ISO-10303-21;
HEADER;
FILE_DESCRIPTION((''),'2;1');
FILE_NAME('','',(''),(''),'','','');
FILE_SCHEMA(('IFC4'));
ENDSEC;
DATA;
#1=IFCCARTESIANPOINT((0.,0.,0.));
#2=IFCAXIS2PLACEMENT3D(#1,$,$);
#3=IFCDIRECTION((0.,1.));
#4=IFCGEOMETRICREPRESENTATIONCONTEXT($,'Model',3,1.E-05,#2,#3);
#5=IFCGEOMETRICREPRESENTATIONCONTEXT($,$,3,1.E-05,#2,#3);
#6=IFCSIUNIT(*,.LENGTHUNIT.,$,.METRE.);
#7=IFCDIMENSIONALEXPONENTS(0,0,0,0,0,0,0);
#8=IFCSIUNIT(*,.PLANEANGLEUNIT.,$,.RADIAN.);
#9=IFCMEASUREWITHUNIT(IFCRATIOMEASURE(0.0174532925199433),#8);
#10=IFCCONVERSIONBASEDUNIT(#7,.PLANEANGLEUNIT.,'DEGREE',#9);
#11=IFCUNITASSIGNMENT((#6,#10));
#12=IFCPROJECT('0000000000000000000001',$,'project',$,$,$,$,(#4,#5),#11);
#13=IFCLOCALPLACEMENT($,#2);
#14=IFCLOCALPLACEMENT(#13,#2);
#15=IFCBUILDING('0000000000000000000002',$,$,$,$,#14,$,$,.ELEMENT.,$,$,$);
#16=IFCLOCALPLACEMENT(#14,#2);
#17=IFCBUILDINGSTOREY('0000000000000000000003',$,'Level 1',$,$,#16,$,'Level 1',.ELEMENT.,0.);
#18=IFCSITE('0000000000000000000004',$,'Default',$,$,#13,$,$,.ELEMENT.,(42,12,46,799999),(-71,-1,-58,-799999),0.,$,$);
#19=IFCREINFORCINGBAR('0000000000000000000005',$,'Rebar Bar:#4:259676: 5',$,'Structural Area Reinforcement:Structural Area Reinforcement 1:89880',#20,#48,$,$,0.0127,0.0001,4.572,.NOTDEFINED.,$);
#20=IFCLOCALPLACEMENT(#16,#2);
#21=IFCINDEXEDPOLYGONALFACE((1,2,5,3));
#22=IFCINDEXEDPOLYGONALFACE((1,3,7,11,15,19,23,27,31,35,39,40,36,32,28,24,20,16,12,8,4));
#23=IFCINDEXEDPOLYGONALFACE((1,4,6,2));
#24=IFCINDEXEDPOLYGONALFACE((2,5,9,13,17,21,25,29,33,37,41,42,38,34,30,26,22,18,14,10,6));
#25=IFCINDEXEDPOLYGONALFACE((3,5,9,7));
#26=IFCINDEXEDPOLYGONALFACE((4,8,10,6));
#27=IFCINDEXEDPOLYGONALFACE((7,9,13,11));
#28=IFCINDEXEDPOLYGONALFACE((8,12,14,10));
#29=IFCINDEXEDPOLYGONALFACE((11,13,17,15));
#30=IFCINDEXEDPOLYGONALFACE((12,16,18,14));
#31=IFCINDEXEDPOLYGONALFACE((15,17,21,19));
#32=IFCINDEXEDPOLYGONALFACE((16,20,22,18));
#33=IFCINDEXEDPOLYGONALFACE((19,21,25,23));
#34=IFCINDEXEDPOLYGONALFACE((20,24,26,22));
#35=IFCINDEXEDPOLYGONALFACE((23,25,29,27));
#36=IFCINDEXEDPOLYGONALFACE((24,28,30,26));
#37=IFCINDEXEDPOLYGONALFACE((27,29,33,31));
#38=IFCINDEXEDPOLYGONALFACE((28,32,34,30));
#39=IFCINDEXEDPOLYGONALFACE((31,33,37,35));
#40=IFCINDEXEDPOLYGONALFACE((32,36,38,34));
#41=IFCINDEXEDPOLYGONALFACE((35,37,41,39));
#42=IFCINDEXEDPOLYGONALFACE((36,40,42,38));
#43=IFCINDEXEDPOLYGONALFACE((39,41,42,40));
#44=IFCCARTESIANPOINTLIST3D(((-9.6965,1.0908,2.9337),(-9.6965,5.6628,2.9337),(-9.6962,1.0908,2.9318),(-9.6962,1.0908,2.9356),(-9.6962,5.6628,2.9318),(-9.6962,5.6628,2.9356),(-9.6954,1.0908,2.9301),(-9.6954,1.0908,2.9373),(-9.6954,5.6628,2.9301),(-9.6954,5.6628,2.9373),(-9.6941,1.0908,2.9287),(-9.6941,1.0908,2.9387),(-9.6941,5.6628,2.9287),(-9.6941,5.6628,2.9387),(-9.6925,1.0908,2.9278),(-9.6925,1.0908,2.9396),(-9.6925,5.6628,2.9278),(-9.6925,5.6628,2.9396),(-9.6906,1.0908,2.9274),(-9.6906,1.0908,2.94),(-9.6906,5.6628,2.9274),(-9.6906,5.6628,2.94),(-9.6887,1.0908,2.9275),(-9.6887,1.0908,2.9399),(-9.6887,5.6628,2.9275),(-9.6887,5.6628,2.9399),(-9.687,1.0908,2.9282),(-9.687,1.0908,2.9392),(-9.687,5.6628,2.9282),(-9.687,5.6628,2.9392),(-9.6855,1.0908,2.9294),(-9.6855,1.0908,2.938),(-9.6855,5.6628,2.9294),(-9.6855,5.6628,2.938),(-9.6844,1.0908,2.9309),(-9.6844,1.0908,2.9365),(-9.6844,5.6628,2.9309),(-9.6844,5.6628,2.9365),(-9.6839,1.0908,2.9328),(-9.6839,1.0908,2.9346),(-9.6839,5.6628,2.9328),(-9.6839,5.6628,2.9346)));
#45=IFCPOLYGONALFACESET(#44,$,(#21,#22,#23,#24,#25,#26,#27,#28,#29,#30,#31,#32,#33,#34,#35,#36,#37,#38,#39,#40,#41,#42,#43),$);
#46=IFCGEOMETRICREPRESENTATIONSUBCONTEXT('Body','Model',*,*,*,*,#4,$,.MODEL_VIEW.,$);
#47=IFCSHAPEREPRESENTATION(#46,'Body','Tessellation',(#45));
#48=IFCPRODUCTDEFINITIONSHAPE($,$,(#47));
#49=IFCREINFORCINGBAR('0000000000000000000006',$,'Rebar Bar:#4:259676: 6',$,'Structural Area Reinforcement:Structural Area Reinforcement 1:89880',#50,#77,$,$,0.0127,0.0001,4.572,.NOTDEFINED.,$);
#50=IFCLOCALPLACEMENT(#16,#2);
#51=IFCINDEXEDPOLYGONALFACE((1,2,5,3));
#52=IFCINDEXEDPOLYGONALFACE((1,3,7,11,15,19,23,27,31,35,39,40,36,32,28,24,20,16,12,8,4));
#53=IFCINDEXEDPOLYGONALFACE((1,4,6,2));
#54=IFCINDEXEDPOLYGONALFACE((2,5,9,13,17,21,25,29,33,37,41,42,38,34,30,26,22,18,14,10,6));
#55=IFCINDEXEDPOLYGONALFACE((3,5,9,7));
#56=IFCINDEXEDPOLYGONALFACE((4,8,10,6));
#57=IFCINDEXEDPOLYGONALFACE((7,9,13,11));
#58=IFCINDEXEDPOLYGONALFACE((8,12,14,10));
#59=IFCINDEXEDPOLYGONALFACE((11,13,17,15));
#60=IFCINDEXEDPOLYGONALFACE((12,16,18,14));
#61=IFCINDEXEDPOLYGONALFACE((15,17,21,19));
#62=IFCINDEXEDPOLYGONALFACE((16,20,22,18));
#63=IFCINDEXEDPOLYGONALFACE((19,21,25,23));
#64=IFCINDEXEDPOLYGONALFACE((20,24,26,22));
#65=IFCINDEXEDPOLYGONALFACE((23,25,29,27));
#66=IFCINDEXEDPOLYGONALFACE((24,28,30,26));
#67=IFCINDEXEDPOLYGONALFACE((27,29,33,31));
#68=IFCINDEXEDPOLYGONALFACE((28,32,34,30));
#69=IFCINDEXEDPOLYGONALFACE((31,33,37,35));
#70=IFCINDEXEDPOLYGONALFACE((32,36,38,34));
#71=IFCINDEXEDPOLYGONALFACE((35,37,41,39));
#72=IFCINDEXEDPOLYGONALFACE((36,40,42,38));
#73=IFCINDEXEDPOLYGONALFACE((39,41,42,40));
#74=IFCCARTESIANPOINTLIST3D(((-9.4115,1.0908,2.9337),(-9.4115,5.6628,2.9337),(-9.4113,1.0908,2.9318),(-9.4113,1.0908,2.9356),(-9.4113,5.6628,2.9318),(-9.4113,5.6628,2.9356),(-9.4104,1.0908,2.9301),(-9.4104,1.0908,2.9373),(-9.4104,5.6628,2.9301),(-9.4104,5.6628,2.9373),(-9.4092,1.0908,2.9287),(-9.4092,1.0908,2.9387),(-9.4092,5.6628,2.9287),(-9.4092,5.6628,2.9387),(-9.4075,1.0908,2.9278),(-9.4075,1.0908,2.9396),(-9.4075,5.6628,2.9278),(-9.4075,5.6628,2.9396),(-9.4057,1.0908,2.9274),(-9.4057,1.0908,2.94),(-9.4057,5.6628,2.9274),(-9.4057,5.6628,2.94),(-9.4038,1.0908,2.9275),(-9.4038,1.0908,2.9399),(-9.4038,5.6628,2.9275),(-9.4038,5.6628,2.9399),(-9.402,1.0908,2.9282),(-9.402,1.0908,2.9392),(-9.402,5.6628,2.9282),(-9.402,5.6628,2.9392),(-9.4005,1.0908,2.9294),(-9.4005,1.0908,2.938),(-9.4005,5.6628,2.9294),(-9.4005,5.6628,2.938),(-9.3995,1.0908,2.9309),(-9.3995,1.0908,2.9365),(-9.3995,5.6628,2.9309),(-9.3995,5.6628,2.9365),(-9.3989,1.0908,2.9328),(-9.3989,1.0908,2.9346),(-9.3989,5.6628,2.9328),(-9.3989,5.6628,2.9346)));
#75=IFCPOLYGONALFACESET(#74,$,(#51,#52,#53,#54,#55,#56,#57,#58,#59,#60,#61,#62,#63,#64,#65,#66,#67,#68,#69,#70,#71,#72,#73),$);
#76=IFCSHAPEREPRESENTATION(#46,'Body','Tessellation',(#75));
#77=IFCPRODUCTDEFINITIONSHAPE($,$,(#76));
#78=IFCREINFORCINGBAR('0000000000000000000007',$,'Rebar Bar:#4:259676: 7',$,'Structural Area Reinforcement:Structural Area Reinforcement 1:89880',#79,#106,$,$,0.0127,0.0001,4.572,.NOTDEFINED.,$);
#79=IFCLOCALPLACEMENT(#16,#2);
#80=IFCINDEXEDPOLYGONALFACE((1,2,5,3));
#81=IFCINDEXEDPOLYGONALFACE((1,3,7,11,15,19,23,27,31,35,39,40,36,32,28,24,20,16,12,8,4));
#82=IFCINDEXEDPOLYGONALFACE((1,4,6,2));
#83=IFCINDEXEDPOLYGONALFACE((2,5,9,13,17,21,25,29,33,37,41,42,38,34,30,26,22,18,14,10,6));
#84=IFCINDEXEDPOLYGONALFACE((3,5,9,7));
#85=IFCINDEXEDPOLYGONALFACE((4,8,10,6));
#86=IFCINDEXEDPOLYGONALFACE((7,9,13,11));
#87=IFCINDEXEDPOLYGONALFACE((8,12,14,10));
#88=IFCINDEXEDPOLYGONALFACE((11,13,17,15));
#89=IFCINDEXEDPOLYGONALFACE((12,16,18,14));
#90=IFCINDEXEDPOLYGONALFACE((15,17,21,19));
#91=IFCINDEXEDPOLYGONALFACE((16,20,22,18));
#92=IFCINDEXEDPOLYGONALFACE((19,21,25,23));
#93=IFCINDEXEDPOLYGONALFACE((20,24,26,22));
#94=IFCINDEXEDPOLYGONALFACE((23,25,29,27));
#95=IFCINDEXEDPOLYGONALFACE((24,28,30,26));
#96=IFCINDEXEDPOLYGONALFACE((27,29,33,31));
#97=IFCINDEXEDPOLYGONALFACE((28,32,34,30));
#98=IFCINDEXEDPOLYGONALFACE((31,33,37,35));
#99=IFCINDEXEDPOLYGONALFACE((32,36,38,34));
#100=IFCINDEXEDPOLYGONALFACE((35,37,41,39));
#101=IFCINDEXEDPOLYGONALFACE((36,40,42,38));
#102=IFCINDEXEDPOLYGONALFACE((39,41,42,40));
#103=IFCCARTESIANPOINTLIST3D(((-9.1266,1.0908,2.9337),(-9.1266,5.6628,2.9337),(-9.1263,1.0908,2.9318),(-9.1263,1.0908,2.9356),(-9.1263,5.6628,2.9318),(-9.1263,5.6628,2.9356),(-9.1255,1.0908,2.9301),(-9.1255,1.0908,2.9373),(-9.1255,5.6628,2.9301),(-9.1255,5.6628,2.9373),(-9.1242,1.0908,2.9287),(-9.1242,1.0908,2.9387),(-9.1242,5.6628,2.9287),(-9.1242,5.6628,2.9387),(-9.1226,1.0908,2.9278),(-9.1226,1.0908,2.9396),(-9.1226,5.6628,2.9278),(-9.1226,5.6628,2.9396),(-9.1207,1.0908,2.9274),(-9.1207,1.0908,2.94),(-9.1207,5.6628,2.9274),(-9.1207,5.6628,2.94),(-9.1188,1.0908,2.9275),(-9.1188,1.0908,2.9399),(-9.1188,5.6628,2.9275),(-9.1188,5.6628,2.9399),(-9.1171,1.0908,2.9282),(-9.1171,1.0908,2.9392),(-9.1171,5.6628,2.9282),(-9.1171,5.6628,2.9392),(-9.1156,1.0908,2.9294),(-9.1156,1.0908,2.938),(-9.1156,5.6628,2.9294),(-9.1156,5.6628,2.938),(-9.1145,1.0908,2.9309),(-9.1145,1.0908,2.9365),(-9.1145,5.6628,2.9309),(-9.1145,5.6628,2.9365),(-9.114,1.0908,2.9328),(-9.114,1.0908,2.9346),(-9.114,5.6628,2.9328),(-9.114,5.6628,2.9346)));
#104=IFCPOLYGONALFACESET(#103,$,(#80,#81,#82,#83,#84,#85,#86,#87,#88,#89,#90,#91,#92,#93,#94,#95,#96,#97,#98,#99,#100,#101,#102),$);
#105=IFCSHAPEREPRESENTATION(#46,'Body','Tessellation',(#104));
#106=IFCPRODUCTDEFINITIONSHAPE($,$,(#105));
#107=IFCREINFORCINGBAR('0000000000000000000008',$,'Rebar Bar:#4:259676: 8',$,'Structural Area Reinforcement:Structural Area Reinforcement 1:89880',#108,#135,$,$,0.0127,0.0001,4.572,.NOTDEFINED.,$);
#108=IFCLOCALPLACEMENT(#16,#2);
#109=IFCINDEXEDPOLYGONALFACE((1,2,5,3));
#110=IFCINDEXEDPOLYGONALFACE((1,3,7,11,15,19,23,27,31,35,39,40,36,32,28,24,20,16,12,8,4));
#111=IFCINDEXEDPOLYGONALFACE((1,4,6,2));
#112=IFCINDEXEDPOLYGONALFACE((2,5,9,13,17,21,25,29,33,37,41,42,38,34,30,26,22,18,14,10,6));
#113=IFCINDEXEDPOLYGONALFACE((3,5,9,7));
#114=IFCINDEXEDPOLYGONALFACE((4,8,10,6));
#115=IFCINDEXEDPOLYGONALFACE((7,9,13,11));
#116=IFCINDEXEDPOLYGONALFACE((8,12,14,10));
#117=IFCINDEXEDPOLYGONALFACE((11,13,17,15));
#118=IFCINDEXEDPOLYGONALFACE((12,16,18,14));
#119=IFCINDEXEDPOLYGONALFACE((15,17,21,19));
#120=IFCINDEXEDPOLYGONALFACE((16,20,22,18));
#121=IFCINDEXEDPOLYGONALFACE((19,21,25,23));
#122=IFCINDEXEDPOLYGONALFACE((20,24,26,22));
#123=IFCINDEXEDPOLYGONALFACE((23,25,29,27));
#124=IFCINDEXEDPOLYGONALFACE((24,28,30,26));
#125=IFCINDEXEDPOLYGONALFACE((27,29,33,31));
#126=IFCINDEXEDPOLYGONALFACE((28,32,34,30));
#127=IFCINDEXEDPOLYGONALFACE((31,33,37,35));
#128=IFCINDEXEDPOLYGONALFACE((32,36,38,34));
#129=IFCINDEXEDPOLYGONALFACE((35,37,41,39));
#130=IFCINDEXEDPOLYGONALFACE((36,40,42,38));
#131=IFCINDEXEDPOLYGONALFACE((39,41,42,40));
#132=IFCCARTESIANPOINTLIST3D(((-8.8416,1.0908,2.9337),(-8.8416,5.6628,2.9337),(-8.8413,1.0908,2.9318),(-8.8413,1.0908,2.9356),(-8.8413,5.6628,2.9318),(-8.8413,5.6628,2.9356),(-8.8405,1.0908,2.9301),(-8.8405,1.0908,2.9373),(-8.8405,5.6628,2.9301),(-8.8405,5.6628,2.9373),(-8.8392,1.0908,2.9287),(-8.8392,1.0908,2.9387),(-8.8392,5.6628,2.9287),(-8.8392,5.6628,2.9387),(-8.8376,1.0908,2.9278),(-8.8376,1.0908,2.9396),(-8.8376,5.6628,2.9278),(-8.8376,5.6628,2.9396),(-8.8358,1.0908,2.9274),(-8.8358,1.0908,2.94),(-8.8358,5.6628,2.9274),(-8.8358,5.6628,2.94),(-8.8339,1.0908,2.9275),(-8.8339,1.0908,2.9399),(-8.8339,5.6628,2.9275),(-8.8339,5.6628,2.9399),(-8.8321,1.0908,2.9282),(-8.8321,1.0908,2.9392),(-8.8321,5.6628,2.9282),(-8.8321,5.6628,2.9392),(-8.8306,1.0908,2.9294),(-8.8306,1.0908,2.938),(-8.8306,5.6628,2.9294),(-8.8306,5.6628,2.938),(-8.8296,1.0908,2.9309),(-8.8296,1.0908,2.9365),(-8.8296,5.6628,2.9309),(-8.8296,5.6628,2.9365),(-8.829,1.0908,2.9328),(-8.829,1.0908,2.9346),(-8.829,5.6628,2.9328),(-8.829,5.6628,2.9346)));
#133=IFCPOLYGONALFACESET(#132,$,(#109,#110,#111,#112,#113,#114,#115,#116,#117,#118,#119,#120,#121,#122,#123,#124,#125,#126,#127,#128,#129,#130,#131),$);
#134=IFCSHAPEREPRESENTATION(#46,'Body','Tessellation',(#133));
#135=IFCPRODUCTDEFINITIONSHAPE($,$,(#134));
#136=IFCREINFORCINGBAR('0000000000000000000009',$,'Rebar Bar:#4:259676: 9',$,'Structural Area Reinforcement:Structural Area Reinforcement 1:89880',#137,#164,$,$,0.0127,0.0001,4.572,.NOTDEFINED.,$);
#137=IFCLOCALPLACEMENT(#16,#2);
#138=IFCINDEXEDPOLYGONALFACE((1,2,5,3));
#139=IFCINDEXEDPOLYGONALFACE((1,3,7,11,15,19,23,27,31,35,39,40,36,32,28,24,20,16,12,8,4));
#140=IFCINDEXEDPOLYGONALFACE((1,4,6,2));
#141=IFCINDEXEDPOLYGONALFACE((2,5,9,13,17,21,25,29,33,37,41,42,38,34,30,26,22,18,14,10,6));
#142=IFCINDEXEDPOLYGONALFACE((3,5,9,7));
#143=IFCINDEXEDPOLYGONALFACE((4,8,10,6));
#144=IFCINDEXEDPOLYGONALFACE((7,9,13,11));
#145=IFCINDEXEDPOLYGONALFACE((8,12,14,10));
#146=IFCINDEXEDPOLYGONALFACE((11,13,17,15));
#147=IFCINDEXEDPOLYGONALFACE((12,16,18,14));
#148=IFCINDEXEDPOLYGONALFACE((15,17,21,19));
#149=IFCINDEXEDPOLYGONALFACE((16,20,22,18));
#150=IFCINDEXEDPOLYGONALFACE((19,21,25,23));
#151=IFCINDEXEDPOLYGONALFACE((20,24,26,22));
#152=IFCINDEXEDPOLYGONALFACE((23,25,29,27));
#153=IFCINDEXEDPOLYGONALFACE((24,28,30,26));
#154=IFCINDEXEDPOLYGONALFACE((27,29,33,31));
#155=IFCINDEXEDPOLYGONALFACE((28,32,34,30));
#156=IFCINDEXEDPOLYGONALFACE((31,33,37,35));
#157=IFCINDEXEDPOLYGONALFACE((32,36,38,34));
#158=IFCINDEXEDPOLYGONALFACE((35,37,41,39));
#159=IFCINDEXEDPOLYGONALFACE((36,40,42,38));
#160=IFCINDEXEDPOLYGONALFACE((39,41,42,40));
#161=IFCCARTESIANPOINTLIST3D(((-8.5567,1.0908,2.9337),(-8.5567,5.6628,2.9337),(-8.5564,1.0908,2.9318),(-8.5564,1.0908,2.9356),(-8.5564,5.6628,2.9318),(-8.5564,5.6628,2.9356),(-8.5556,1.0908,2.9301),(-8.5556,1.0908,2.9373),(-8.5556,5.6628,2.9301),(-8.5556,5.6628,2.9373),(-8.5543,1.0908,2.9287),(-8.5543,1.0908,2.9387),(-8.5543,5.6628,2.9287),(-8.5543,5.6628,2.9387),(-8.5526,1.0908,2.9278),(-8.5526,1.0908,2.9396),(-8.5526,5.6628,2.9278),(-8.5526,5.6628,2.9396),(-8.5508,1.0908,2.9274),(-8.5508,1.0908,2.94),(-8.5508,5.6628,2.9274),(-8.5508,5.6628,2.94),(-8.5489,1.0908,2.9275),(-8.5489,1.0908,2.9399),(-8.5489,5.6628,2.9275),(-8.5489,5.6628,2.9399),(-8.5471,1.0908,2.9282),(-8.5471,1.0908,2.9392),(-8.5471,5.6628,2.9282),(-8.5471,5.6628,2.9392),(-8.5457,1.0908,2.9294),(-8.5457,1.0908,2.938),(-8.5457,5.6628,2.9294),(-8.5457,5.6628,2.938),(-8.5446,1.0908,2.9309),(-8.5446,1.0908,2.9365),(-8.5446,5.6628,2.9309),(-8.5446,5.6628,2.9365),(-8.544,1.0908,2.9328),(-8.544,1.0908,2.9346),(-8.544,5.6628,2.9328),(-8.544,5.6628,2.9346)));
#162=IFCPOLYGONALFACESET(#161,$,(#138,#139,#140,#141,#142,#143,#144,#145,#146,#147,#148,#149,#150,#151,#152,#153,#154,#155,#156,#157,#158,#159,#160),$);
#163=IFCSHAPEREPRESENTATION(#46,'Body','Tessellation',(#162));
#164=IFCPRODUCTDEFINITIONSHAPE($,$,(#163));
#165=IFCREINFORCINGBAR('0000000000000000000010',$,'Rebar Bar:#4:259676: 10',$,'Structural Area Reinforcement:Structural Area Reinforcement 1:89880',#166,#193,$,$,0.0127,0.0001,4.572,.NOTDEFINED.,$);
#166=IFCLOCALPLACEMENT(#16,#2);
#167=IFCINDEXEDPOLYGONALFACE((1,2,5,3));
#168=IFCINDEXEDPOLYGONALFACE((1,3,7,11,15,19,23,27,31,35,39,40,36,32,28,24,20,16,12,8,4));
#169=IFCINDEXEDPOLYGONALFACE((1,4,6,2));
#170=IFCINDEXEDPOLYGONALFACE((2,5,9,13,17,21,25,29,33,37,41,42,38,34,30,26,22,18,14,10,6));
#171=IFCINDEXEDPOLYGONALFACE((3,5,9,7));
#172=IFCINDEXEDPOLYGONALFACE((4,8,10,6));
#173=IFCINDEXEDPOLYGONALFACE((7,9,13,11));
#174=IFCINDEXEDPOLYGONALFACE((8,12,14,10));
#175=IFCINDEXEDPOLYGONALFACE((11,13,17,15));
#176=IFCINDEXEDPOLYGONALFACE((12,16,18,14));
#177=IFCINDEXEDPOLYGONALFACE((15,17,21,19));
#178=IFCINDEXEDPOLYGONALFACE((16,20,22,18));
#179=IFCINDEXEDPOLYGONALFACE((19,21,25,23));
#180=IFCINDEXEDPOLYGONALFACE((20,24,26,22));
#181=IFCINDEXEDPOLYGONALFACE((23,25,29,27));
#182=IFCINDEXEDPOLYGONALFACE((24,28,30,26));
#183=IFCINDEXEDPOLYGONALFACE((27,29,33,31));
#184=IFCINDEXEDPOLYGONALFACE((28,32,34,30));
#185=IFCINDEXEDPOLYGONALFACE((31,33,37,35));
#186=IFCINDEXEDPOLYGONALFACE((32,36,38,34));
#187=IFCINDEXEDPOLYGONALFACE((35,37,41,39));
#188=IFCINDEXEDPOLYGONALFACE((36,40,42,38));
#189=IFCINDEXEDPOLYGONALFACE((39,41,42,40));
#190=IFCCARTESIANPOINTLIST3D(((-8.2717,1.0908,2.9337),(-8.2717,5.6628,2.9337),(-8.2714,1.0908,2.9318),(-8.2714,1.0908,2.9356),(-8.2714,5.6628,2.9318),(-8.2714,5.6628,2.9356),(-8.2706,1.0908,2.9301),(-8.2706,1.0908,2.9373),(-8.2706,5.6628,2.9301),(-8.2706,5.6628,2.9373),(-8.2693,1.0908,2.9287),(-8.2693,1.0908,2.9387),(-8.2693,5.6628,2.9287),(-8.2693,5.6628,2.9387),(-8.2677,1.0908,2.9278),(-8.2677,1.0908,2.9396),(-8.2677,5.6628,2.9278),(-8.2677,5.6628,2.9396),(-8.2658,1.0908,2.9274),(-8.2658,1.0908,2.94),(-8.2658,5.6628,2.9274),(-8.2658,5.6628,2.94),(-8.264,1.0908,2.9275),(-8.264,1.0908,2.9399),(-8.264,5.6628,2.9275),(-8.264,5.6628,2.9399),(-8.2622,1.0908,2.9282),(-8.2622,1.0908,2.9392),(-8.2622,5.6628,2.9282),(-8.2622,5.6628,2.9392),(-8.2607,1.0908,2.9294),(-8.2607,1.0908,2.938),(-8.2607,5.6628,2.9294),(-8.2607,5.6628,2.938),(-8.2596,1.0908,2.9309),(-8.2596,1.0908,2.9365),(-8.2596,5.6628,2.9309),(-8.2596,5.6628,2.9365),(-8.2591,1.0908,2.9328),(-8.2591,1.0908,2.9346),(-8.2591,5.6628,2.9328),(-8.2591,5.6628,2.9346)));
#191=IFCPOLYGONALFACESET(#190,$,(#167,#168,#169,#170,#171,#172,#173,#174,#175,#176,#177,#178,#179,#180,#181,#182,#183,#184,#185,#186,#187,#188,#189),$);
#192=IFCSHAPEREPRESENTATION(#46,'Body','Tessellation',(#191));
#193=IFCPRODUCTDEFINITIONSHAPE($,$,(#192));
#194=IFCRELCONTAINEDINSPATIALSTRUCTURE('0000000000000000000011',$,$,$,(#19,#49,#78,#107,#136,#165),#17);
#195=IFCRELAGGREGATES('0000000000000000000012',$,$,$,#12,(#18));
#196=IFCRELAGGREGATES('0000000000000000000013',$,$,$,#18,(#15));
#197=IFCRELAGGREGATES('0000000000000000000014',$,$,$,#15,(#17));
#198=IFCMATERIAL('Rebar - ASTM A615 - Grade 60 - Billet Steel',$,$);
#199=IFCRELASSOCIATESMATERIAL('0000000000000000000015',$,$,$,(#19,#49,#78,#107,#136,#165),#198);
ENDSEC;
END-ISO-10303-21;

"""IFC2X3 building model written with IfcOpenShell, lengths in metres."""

from ifc_helpers import new_model, entity, si_unit, converted_unit, direction, origin, place, context, subcontext, project, spatial, material, element, save


model = new_model("IFC2X3")

# Units and contexts
model_context = context("Model", 3, precision=1e-05, world=origin(), true_north=direction((0.0, 1.0)))
context_of_model = context(None, 3, precision=1e-05, world=origin(), true_north=direction((0.0, 1.0)))
body_context = subcontext(model_context, "Body", "Model", "MODEL_VIEW")
ifc_project = project(units=[si_unit("LENGTHUNIT", "METRE"), converted_unit("PLANEANGLEUNIT", "DEGREE", entity("IfcRatioMeasure", 0.0174532925199433), si_unit("PLANEANGLEUNIT", "RADIAN"), dimensions=[0, 0, 0, 0, 0, 0, 0])], contexts=[model_context, context_of_model])

# Site, building, storey
site_placement = place(None, origin())
site = spatial("IfcSite", under=ifc_project, at=site_placement, Name="Default", CompositionType="ELEMENT", RefLatitude=(42, 12, 46, 799999), RefLongitude=(-71, -1, -58, -799999), RefElevation=0.0)
building_placement = place(site_placement, origin())
building = spatial("IfcBuilding", under=site, at=building_placement, CompositionType="ELEMENT")
storey_placement = place(building_placement, origin())
storey = spatial("IfcBuildingStorey", under=building, at=storey_placement, Name="Level 1", LongName="Level 1", CompositionType="ELEMENT", Elevation=0.0)

# Reinforcing bars
ifc_material_1 = material(Name="Rebar - ASTM A615 - Grade 60 - Billet Steel")
reinforcing_bar_1_placement = place(storey_placement, origin())
element("IfcReinforcingBar", 1, at=reinforcing_bar_1_placement, inside=storey, material=ifc_material_1, Name="Rebar Bar:#4:259676: 5", ObjectType="Structural Area Reinforcement:Structural Area Reinforcement 1:89880", BarLength=4.572, BarRole="NOTDEFINED", CrossSectionArea=0.0001, NominalDiameter=0.0127, context=body_context, shape_type="AdvancedSweptSolid", body=[
    entity("IfcSweptDiskSolid", entity("IfcCompositeCurve", [entity("IfcCompositeCurveSegment", "CONTINUOUS", True, entity("IfcPolyline", [entity("IfcCartesianPoint", [-9.6901, 5.6628, 2.9337]), entity("IfcCartesianPoint", [-9.6901, 1.0908, 2.9337])]))], False), 0.0063, None, 0.0, 1.0),
])
reinforcing_bar_2_placement = place(storey_placement, origin())
element("IfcReinforcingBar", 2, at=reinforcing_bar_2_placement, inside=storey, material=ifc_material_1, Name="Rebar Bar:#4:259676: 6", ObjectType="Structural Area Reinforcement:Structural Area Reinforcement 1:89880", BarLength=4.572, BarRole="NOTDEFINED", CrossSectionArea=0.0001, NominalDiameter=0.0127, context=body_context, shape_type="AdvancedSweptSolid", body=[
    entity("IfcSweptDiskSolid", entity("IfcCompositeCurve", [entity("IfcCompositeCurveSegment", "CONTINUOUS", True, entity("IfcPolyline", [entity("IfcCartesianPoint", [-9.4052, 5.6628, 2.9337]), entity("IfcCartesianPoint", [-9.4052, 1.0908, 2.9337])]))], False), 0.0063, None, 0.0, 1.0),
])
reinforcing_bar_3_placement = place(storey_placement, origin())
element("IfcReinforcingBar", 3, at=reinforcing_bar_3_placement, inside=storey, material=ifc_material_1, Name="Rebar Bar:#4:259676: 7", ObjectType="Structural Area Reinforcement:Structural Area Reinforcement 1:89880", BarLength=4.572, BarRole="NOTDEFINED", CrossSectionArea=0.0001, NominalDiameter=0.0127, context=body_context, shape_type="AdvancedSweptSolid", body=[
    entity("IfcSweptDiskSolid", entity("IfcCompositeCurve", [entity("IfcCompositeCurveSegment", "CONTINUOUS", True, entity("IfcPolyline", [entity("IfcCartesianPoint", [-9.1202, 5.6628, 2.9337]), entity("IfcCartesianPoint", [-9.1202, 1.0908, 2.9337])]))], False), 0.0063, None, 0.0, 1.0),
])
reinforcing_bar_4_placement = place(storey_placement, origin())
element("IfcReinforcingBar", 4, at=reinforcing_bar_4_placement, inside=storey, material=ifc_material_1, Name="Rebar Bar:#4:259676: 8", ObjectType="Structural Area Reinforcement:Structural Area Reinforcement 1:89880", BarLength=4.572, BarRole="NOTDEFINED", CrossSectionArea=0.0001, NominalDiameter=0.0127, context=body_context, shape_type="AdvancedSweptSolid", body=[
    entity("IfcSweptDiskSolid", entity("IfcCompositeCurve", [entity("IfcCompositeCurveSegment", "CONTINUOUS", True, entity("IfcPolyline", [entity("IfcCartesianPoint", [-8.8353, 5.6628, 2.9337]), entity("IfcCartesianPoint", [-8.8353, 1.0908, 2.9337])]))], False), 0.0063, None, 0.0, 1.0),
])
reinforcing_bar_5_placement = place(storey_placement, origin())
element("IfcReinforcingBar", 5, at=reinforcing_bar_5_placement, inside=storey, material=ifc_material_1, Name="Rebar Bar:#4:259676: 9", ObjectType="Structural Area Reinforcement:Structural Area Reinforcement 1:89880", BarLength=4.572, BarRole="NOTDEFINED", CrossSectionArea=0.0001, NominalDiameter=0.0127, context=body_context, shape_type="AdvancedSweptSolid", body=[
    entity("IfcSweptDiskSolid", entity("IfcCompositeCurve", [entity("IfcCompositeCurveSegment", "CONTINUOUS", True, entity("IfcPolyline", [entity("IfcCartesianPoint", [-8.5503, 5.6628, 2.9337]), entity("IfcCartesianPoint", [-8.5503, 1.0908, 2.9337])]))], False), 0.0063, None, 0.0, 1.0),
])
reinforcing_bar_6_placement = place(storey_placement, origin())
element("IfcReinforcingBar", 6, at=reinforcing_bar_6_placement, inside=storey, material=ifc_material_1, Name="Rebar Bar:#4:259676: 10", ObjectType="Structural Area Reinforcement:Structural Area Reinforcement 1:89880", BarLength=4.572, BarRole="NOTDEFINED", CrossSectionArea=0.0001, NominalDiameter=0.0127, context=body_context, shape_type="AdvancedSweptSolid", body=[
    entity("IfcSweptDiskSolid", entity("IfcCompositeCurve", [entity("IfcCompositeCurveSegment", "CONTINUOUS", True, entity("IfcPolyline", [entity("IfcCartesianPoint", [-8.2654, 5.6628, 2.9337]), entity("IfcCartesianPoint", [-8.2654, 1.0908, 2.9337])]))], False), 0.0063, None, 0.0, 1.0),
])

save(model, "model.ifc")
